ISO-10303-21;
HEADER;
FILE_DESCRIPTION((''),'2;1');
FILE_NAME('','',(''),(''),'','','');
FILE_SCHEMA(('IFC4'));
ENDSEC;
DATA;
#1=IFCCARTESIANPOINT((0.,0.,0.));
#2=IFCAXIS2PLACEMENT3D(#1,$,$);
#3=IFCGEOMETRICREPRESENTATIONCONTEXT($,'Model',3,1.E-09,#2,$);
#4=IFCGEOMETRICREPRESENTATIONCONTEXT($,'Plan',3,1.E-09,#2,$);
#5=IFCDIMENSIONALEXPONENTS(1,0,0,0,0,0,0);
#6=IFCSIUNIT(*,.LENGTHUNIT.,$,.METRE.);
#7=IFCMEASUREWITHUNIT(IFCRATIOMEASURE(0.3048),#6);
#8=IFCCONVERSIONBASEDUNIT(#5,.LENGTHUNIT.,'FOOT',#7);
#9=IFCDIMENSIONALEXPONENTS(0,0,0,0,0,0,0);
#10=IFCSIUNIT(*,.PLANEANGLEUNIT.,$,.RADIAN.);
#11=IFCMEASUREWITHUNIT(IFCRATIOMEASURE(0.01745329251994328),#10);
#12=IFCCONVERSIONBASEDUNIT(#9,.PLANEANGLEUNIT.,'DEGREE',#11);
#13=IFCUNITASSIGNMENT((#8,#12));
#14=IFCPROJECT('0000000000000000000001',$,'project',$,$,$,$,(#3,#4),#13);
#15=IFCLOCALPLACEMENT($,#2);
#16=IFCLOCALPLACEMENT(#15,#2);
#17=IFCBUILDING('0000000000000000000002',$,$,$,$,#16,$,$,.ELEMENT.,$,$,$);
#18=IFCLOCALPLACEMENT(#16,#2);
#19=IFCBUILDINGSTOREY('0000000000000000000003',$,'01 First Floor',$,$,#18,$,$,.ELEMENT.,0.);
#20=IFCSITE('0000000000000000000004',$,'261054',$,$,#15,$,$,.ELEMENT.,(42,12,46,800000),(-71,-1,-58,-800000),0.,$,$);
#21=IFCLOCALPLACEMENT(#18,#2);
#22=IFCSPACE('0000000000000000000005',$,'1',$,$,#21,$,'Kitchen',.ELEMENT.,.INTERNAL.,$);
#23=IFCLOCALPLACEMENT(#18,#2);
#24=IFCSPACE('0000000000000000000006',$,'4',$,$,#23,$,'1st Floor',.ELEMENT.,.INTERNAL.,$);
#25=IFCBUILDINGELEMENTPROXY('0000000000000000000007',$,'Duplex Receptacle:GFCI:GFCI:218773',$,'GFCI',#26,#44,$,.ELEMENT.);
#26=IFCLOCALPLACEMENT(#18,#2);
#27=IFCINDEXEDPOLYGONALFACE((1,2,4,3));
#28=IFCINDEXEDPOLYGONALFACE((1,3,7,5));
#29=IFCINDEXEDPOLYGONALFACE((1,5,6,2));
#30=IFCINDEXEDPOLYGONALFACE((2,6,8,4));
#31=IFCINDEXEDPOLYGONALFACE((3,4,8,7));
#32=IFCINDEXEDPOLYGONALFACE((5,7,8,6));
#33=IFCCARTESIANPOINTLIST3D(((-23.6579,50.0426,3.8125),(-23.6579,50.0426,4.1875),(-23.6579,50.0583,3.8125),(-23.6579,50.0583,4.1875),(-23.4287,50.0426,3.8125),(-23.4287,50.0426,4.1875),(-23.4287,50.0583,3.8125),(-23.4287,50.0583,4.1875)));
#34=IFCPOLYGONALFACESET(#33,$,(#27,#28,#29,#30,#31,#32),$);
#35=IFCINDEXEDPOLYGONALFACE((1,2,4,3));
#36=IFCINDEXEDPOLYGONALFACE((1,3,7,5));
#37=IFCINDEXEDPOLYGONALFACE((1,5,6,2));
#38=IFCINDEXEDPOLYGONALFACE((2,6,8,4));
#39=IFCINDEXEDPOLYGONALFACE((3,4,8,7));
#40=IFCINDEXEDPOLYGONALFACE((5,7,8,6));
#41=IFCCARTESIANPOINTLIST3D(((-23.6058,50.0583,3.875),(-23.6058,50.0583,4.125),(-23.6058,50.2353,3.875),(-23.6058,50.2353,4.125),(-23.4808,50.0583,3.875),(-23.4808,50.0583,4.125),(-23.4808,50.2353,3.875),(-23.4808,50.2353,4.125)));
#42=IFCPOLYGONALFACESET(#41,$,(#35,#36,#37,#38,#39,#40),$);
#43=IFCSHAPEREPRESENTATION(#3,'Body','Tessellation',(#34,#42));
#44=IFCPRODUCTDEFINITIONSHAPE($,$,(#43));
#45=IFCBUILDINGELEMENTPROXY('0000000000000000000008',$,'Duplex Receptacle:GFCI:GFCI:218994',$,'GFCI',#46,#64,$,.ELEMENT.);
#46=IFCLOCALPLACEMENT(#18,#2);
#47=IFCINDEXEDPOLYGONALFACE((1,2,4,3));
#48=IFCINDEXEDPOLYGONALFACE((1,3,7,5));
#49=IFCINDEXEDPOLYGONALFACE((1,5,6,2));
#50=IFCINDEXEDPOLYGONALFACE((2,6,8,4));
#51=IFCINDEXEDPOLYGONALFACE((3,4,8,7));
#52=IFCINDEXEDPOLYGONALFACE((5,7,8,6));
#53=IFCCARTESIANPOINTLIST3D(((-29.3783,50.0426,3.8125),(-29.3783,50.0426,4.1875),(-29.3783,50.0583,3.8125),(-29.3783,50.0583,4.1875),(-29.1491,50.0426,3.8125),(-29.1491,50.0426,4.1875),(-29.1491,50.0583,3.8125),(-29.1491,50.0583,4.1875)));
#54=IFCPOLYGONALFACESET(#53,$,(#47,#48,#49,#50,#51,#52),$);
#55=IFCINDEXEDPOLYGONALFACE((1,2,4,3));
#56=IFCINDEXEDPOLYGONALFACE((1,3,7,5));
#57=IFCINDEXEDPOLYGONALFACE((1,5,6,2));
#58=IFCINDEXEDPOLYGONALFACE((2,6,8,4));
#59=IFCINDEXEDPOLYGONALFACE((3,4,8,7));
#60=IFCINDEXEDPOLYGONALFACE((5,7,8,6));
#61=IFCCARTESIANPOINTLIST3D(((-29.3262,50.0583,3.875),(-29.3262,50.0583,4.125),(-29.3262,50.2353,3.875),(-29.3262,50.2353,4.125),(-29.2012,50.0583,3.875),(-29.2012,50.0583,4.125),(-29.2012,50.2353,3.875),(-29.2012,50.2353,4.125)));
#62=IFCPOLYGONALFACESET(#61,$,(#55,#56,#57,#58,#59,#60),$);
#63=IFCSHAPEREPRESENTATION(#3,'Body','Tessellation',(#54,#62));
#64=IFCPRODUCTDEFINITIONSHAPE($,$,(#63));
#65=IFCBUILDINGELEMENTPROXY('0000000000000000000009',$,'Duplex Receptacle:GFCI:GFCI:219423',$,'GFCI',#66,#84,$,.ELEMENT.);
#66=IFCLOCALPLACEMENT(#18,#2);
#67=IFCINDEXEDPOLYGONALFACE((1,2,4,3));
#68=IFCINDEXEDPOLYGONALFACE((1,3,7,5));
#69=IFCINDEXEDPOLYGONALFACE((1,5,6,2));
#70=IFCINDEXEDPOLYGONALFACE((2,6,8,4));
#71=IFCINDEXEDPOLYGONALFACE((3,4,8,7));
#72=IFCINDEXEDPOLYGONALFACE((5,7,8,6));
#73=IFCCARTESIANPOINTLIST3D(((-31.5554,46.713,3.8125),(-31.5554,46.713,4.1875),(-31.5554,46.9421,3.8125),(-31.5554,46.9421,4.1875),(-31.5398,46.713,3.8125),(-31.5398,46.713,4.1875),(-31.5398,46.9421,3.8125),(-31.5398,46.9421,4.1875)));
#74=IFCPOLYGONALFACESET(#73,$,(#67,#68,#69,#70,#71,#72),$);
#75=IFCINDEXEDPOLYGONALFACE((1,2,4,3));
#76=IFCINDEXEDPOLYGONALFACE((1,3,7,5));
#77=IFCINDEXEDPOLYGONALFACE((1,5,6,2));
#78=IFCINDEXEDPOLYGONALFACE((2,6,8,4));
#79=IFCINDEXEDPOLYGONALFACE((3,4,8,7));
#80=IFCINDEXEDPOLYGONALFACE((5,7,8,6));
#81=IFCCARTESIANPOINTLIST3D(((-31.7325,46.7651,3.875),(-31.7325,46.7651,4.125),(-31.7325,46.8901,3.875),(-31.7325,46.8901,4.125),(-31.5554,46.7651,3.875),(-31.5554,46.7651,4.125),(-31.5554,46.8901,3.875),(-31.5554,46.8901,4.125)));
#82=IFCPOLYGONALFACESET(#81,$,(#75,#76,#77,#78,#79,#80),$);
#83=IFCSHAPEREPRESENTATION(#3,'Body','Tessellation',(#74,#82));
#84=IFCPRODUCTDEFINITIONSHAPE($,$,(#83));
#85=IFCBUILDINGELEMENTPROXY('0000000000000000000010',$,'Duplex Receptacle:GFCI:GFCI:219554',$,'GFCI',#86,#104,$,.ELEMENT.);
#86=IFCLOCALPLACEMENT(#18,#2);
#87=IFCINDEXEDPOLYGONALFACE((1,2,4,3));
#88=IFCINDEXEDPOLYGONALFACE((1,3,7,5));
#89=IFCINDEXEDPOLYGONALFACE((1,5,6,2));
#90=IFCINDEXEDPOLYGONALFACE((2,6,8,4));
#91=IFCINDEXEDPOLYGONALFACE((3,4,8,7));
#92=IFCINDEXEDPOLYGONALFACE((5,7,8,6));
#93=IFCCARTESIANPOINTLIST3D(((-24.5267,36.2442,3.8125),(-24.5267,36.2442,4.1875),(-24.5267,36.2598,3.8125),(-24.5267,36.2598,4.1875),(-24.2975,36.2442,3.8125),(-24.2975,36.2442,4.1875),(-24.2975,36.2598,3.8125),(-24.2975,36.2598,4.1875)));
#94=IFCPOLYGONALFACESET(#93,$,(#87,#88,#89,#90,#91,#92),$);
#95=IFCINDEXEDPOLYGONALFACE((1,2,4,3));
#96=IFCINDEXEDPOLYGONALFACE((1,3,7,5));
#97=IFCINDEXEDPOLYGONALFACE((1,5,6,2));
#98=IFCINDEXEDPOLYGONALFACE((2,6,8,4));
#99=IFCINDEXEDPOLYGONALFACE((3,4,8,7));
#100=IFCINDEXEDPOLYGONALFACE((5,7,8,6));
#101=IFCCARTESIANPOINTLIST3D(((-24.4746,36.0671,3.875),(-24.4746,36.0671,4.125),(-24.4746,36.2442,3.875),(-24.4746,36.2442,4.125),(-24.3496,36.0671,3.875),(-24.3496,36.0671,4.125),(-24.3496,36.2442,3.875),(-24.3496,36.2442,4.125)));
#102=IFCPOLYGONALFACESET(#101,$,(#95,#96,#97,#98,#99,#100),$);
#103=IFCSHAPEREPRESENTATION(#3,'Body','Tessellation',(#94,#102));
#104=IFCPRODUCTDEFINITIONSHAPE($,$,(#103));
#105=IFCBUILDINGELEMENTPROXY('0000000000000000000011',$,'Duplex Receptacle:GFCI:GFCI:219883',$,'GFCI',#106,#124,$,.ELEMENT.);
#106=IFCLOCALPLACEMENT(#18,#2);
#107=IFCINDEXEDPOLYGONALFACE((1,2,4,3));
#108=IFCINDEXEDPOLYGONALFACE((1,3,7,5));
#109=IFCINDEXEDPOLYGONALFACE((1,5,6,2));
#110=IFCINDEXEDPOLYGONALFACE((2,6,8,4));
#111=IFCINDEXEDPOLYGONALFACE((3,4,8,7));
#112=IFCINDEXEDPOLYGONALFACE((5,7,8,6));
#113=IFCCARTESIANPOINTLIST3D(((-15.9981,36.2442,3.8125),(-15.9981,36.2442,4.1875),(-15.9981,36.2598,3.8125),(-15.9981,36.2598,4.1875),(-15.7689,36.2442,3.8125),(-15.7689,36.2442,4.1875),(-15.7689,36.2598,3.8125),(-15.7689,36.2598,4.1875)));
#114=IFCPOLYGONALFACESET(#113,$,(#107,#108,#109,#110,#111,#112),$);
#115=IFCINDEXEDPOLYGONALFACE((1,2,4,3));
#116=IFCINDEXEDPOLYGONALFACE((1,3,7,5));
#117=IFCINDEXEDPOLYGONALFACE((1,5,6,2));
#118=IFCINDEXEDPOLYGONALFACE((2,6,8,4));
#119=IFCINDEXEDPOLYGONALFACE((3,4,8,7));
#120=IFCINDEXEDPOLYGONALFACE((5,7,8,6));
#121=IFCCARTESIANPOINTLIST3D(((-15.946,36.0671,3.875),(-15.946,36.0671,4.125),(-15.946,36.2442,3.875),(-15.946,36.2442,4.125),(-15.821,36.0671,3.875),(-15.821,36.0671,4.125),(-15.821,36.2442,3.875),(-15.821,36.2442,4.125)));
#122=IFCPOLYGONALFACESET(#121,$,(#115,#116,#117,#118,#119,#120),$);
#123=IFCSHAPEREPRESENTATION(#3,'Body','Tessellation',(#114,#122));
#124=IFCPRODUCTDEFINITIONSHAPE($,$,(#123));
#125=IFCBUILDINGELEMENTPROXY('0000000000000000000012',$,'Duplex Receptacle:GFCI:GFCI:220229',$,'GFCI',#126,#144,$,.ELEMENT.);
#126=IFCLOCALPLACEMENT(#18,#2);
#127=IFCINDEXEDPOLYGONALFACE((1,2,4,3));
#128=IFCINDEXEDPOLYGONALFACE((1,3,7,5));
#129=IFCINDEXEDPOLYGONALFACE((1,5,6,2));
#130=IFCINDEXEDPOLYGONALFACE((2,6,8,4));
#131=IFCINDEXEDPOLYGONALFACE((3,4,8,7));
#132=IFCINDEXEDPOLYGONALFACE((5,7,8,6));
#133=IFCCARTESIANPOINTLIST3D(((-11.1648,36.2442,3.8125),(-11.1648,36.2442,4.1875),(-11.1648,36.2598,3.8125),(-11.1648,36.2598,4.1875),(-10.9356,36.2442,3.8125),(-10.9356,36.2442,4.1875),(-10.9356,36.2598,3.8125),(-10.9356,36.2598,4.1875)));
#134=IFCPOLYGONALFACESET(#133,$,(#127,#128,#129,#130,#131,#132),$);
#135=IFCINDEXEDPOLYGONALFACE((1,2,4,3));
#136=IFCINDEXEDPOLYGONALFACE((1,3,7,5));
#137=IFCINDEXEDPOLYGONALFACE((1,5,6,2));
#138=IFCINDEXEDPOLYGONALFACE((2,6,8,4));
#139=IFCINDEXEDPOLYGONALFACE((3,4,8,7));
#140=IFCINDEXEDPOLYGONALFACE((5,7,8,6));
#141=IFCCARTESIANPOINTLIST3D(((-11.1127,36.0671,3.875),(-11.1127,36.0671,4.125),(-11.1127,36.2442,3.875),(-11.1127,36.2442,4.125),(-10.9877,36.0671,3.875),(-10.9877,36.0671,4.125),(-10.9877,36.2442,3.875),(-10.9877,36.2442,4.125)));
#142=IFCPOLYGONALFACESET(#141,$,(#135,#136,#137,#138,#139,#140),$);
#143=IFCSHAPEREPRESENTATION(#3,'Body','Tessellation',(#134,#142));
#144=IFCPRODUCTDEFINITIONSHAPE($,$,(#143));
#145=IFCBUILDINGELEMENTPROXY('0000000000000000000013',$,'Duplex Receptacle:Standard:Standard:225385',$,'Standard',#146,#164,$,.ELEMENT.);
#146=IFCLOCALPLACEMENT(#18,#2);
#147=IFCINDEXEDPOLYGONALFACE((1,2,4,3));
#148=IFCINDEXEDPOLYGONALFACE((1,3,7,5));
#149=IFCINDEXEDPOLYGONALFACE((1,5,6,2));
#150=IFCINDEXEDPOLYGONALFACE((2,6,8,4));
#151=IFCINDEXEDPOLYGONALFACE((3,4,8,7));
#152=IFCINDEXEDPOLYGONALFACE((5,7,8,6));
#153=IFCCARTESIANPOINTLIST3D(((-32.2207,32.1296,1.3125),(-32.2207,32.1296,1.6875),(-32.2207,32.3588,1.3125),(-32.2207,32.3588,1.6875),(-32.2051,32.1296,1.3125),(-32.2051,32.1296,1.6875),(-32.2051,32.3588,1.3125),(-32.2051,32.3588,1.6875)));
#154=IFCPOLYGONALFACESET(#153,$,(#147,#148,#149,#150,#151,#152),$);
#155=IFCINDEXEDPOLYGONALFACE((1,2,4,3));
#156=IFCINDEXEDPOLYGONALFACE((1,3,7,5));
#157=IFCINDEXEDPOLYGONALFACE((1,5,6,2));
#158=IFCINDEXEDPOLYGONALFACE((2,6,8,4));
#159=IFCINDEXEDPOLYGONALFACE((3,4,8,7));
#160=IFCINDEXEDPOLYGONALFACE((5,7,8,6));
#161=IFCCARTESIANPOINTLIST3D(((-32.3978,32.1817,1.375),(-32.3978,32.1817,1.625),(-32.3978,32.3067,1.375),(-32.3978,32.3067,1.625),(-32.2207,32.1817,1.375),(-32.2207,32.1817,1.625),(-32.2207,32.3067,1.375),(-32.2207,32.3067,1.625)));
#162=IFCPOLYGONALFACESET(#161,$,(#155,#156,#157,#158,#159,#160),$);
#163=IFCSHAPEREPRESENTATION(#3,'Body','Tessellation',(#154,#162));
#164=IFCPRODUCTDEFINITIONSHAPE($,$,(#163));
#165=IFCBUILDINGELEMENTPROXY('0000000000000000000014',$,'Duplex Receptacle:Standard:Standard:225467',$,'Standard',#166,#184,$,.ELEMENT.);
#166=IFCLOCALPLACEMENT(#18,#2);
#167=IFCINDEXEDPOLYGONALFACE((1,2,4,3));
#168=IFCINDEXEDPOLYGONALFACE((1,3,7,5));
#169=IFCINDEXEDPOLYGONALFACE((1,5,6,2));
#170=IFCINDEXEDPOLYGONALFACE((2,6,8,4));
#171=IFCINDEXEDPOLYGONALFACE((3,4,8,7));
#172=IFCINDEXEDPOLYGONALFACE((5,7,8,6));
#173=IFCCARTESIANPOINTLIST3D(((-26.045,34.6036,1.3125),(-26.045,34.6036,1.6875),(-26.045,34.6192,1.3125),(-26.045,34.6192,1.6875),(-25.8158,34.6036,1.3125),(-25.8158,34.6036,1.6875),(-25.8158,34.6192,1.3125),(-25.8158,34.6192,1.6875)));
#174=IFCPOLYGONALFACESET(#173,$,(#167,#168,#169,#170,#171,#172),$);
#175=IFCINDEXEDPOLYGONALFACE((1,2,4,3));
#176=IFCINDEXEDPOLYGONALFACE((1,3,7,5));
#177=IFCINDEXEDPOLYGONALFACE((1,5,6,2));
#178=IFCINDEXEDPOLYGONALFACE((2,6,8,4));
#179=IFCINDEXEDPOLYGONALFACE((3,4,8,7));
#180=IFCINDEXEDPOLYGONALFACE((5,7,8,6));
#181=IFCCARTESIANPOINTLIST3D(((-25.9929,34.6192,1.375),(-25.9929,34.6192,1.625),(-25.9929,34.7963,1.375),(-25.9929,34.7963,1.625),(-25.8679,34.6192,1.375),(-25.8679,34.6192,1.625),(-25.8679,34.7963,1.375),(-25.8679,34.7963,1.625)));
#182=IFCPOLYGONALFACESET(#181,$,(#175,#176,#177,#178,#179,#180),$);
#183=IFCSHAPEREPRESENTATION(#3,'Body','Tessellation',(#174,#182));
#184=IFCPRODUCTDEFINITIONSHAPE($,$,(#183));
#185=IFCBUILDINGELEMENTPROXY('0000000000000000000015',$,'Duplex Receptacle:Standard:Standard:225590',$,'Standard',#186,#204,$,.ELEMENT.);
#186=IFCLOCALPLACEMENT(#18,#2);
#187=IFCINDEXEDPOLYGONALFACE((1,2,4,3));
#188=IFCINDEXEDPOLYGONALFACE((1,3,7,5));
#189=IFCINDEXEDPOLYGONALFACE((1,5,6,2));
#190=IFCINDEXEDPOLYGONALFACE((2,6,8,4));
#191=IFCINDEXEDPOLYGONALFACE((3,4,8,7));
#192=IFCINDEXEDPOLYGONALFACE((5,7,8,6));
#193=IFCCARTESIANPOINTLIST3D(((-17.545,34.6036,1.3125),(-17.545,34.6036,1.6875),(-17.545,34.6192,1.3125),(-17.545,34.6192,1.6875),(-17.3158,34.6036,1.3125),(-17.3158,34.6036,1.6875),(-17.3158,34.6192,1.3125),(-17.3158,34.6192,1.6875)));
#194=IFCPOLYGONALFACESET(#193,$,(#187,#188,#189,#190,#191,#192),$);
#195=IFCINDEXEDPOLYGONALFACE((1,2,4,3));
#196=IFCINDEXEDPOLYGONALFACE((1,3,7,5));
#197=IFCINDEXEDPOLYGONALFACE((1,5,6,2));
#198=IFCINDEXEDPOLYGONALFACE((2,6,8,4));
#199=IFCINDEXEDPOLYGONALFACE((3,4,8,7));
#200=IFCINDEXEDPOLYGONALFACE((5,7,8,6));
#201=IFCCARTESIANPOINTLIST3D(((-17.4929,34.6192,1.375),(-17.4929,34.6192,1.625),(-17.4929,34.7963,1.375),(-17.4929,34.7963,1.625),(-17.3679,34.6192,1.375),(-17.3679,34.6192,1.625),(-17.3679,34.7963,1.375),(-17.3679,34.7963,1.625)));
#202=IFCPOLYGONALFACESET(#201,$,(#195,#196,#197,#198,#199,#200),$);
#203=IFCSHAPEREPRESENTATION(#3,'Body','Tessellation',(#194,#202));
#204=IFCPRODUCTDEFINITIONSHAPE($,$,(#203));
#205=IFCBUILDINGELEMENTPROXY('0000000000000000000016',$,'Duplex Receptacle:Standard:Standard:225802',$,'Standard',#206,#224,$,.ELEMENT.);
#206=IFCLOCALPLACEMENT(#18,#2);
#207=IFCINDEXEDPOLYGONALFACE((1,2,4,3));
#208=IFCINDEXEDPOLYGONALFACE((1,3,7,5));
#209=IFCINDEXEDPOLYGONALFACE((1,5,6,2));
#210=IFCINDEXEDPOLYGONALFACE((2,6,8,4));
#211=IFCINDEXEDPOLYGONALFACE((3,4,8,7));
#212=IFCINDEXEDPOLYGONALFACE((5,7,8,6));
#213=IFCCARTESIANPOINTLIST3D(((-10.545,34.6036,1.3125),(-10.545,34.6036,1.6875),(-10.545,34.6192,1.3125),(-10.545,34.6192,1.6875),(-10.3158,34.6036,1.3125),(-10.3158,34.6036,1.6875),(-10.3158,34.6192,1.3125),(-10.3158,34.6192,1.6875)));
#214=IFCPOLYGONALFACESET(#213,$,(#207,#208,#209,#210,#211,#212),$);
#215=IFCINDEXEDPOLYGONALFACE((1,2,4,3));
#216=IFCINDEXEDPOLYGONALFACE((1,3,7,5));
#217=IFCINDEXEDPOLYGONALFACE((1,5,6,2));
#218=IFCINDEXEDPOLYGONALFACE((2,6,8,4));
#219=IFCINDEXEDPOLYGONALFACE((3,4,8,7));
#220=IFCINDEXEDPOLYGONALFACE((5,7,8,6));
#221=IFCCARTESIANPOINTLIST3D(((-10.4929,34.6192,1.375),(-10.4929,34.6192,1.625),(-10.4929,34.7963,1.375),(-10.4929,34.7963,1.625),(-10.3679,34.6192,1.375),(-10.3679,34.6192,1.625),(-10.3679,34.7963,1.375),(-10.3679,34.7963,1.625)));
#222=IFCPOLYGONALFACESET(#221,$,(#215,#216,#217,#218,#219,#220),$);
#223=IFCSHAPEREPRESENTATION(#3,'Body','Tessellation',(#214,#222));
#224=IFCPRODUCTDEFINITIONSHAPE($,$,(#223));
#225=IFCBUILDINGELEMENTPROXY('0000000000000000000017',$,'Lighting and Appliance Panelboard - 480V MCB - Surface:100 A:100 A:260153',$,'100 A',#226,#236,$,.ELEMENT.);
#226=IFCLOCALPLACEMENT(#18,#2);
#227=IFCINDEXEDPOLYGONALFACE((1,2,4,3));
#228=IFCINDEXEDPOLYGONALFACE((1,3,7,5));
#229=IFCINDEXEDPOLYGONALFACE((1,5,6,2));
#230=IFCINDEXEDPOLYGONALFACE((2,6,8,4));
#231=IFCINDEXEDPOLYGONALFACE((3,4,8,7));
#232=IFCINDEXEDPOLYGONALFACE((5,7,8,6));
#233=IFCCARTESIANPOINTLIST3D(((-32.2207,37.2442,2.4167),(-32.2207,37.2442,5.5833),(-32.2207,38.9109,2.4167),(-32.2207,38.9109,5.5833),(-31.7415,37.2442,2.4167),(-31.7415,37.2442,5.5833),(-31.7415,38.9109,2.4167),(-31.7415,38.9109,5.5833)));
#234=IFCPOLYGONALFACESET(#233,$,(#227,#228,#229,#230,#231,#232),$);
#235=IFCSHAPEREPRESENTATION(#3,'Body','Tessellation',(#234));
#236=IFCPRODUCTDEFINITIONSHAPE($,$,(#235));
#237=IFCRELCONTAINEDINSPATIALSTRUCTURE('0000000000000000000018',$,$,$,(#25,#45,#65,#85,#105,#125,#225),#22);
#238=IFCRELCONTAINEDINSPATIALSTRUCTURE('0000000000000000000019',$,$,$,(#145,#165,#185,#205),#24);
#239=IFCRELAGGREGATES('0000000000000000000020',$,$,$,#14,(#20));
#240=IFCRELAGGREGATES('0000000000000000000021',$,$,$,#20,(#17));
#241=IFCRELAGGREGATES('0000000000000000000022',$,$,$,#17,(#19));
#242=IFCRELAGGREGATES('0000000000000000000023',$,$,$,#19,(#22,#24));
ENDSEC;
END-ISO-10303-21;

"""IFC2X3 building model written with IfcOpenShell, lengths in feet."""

from ifc_helpers import new_model, entity, si_unit, converted_unit, frame, origin, origin_2d_with_axis, place, context, project, spatial, rectangle, extrude, source, transform, mapped, element, save


model = new_model("IFC2X3")

# Units and contexts
model_context = context("Model", 3, precision=1e-09, world=origin())
plan_context = context("Plan", 3, precision=1e-09, world=origin())
ifc_project = project(units=[converted_unit("LENGTHUNIT", "FOOT", entity("IfcRatioMeasure", 0.3048), si_unit("LENGTHUNIT", "METRE"), dimensions=[1, 0, 0, 0, 0, 0, 0]), converted_unit("PLANEANGLEUNIT", "DEGREE", entity("IfcRatioMeasure", 0.01745329251994328), si_unit("PLANEANGLEUNIT", "RADIAN"), dimensions=[0, 0, 0, 0, 0, 0, 0])], contexts=[model_context, plan_context])

# Site, building, storey
site_placement = place(None, origin())
site = spatial("IfcSite", under=ifc_project, at=site_placement, Name="261054", CompositionType="ELEMENT", RefLatitude=(42, 12, 46, 800000), RefLongitude=(-71, -1, -58, -800000), RefElevation=0.0)
building_placement = place(site_placement, origin())
building = spatial("IfcBuilding", under=site, at=building_placement, CompositionType="ELEMENT")
storey_placement = place(building_placement, origin())
storey = spatial("IfcBuildingStorey", under=building, at=storey_placement, Name="01 First Floor", CompositionType="ELEMENT", Elevation=0.0)

# Shared definitions
space_1_placement = place(storey_placement, origin())
space_1 = spatial("IfcSpace", under=storey, at=space_1_placement, Name="1", LongName="Kitchen", CompositionType="ELEMENT", InteriorOrExteriorSpace="INTERNAL")

# Shared definitions
space_2_placement = place(storey_placement, origin())
space_2 = spatial("IfcSpace", under=storey, at=space_2_placement, Name="4", LongName="1st Floor", CompositionType="ELEMENT", InteriorOrExteriorSpace="INTERNAL")

# Building element proxies
shared_shape_1 = source(origin(), model_context, "Body", "SweptSolid", [
    extrude(rectangle(XDim=0.2292, YDim=0.375, at=origin_2d_with_axis()), frame((0.0, 0.0, 0.0), z_axis=(0.0, 0.0, 1.0), x_axis=(-1.0, 0.0, 0.0)), (0.0, 0.0, 1.0), 0.0156),
    extrude(rectangle(XDim=0.125, YDim=0.25, at=origin_2d_with_axis()), frame((0.0, 0.0, -0.1771), z_axis=(0.0, 0.0, 1.0), x_axis=(-1.0, 0.0, 0.0)), (0.0, 0.0, 1.0), 0.1771),
])
for number, where, z_axis, x_axis, name in (
    (1, (-23.5433, 50.0583, 4.0), (0.0, -1.0, 0.0), (1.0, 0.0, 0.0), "Duplex Receptacle:GFCI:GFCI:218773"),
    (2, (-29.2637, 50.0583, 4.0), (0.0, -1.0, 0.0), (1.0, 0.0, 0.0), "Duplex Receptacle:GFCI:GFCI:218994"),
    (3, (-31.5554, 46.8276, 4.0), (1.0, 0.0, 0.0), (0.0, 1.0, 0.0), "Duplex Receptacle:GFCI:GFCI:219423"),
    (4, (-24.4121, 36.2442, 4.0), (0.0, 1.0, 0.0), (-1.0, 0.0, 0.0), "Duplex Receptacle:GFCI:GFCI:219554"),
    (5, (-15.8835, 36.2442, 4.0), (0.0, 1.0, 0.0), (-1.0, 0.0, 0.0), "Duplex Receptacle:GFCI:GFCI:219883"),
    (6, (-11.0502, 36.2442, 4.0), (0.0, 1.0, 0.0), (-1.0, 0.0, 0.0), "Duplex Receptacle:GFCI:GFCI:220229"),
):
    element("IfcBuildingElementProxy", number, at=place(space_1_placement, frame(where, z_axis=z_axis, x_axis=x_axis)), inside=space_1, Name=name, ObjectType="GFCI", CompositionType="ELEMENT", context=model_context, shape_type="MappedRepresentation", body=[
        mapped(shared_shape_1, transform((0.0, 0.0, 0.0), scale=1.0)),
    ])
shared_shape_2 = source(origin(), model_context, "Body", "SweptSolid", [
    extrude(rectangle(XDim=0.2292, YDim=0.375, at=origin_2d_with_axis()), frame((0.0, 0.0, 0.0), z_axis=(0.0, 0.0, 1.0), x_axis=(-1.0, 0.0, 0.0)), (0.0, 0.0, 1.0), 0.0156),
    extrude(rectangle(XDim=0.125, YDim=0.25, at=origin_2d_with_axis()), frame((0.0, 0.0, -0.1771), z_axis=(0.0, 0.0, 1.0), x_axis=(-1.0, 0.0, 0.0)), (0.0, 0.0, 1.0), 0.1771),
])
for number, where, z_axis, x_axis, name in (
    (7, (-32.2207, 32.2442, 1.5), (1.0, 0.0, 0.0), (0.0, 1.0, 0.0), "Duplex Receptacle:Standard:Standard:225385"),
    (8, (-25.9304, 34.6192, 1.5), (0.0, -1.0, 0.0), (1.0, 0.0, 0.0), "Duplex Receptacle:Standard:Standard:225467"),
    (9, (-17.4304, 34.6192, 1.5), (0.0, -1.0, 0.0), (1.0, 0.0, 0.0), "Duplex Receptacle:Standard:Standard:225590"),
    (10, (-10.4304, 34.6192, 1.5), (0.0, -1.0, 0.0), (1.0, 0.0, 0.0), "Duplex Receptacle:Standard:Standard:225802"),
):
    element("IfcBuildingElementProxy", number, at=place(space_2_placement, frame(where, z_axis=z_axis, x_axis=x_axis)), inside=space_2, Name=name, ObjectType="Standard", CompositionType="ELEMENT", context=model_context, shape_type="MappedRepresentation", body=[
        mapped(shared_shape_2, transform((0.0, 0.0, 0.0), scale=1.0)),
    ])
shared_shape_3 = source(origin(), model_context, "Body", "SweptSolid", [
    extrude(rectangle(XDim=1.6667, YDim=3.1667, at=origin_2d_with_axis()), frame((0.3333, -1.5833, 0.0), z_axis=(0.0, 0.0, 1.0), x_axis=(-1.0, 0.0, 0.0)), (0.0, 0.0, 1.0), 0.4792),
])
proxy_1_placement = place(space_1_placement, frame((-32.2207, 37.7442, 5.5833), z_axis=(1.0, 0.0, 0.0), x_axis=(0.0, 1.0, 0.0)))
element("IfcBuildingElementProxy", 11, at=proxy_1_placement, inside=space_1, Name="Lighting and Appliance Panelboard - 480V MCB - Surface:100 A:100 A:260153", ObjectType="100 A", CompositionType="ELEMENT", context=model_context, shape_type="MappedRepresentation", body=[
    mapped(shared_shape_3, transform((0.0, 0.0, 0.0), scale=1.0)),
])

save(model, "model.ifc")
